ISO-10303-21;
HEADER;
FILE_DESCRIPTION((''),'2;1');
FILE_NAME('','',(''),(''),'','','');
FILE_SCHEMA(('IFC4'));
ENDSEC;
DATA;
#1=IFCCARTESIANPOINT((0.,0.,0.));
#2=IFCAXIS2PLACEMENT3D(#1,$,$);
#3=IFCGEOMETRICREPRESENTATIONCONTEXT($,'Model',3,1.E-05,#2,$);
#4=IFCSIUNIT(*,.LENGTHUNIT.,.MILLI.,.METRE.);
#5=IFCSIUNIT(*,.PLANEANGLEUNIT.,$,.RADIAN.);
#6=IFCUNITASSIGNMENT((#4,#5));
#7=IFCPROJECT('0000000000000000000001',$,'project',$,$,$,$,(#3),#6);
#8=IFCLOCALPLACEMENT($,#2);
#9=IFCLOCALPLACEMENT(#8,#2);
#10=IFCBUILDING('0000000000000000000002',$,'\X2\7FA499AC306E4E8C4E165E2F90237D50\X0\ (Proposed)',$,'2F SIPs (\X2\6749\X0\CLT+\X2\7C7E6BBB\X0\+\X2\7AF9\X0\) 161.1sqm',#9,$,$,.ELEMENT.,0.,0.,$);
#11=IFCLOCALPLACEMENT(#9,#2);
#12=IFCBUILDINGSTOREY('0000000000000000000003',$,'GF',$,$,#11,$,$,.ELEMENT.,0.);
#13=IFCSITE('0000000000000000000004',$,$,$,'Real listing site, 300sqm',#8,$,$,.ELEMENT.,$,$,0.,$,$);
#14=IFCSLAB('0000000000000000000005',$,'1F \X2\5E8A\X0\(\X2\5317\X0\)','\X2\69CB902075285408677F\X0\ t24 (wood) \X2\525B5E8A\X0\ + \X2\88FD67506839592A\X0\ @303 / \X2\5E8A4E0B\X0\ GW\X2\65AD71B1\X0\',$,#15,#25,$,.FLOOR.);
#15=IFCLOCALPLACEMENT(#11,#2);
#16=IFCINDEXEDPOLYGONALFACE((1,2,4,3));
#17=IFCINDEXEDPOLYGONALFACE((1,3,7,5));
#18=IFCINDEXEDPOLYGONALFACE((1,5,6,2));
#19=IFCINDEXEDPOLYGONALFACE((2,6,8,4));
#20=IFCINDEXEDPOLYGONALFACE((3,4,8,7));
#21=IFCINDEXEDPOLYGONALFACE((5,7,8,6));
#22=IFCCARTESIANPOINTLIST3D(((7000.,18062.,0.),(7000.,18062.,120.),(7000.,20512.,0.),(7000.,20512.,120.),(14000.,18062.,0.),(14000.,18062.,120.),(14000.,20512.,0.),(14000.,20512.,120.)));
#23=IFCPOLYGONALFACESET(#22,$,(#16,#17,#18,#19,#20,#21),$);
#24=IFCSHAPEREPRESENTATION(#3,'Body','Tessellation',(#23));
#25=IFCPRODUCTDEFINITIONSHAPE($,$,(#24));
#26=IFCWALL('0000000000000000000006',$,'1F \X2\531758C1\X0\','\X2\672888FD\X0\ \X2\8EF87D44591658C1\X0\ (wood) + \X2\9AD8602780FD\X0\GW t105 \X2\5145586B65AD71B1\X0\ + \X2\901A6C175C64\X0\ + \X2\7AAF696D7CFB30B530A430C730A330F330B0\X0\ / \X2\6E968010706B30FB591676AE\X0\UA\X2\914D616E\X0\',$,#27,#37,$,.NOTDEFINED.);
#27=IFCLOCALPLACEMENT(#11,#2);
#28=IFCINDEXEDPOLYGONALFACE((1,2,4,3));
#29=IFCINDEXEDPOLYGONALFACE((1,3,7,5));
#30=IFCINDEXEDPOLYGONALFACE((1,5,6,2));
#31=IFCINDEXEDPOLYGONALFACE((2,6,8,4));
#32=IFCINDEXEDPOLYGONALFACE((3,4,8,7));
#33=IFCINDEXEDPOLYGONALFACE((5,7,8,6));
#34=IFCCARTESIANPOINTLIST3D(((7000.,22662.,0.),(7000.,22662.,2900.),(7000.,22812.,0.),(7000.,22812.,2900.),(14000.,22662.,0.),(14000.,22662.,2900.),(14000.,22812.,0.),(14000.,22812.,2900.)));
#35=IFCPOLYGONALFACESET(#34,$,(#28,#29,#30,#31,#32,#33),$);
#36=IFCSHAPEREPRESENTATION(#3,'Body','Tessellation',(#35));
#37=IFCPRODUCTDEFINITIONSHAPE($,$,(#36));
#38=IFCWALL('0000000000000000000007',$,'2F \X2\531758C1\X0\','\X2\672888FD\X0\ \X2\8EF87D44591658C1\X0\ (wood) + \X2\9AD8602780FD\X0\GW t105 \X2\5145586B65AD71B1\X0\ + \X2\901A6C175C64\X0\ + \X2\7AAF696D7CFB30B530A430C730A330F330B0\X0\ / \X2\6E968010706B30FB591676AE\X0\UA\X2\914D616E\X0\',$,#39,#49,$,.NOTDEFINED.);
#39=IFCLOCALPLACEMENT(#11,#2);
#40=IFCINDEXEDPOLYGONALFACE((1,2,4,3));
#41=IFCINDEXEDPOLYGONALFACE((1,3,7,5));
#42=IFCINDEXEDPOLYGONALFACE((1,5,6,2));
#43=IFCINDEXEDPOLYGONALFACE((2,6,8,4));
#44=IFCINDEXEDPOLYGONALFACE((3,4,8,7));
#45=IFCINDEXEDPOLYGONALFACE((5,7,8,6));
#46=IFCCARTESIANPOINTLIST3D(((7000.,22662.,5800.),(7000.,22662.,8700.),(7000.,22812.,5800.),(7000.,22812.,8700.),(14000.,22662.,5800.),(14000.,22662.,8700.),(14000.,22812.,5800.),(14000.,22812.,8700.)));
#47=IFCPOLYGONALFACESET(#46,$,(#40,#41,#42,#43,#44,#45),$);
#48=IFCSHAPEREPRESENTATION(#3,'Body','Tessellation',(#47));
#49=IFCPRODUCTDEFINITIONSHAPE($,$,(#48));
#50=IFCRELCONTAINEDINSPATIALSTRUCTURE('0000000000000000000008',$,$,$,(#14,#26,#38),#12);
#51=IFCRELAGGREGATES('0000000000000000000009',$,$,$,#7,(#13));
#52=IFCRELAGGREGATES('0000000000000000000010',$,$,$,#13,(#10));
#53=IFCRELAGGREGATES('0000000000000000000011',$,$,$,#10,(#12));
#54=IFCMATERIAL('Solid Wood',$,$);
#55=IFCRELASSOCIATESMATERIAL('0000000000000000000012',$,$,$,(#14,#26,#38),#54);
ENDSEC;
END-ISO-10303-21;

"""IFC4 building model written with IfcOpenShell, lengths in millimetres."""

from ifc_helpers import new_model, si_unit, frame, frame_2d, origin, place, context, project, spatial, rectangle, extrude, material, element, save


model = new_model("IFC4")

# Units and contexts
model_context = context("Model", 3, precision=1e-05, world=origin())
ifc_project = project(units=[si_unit("LENGTHUNIT", "METRE", prefix="MILLI"), si_unit("PLANEANGLEUNIT", "RADIAN")], contexts=[model_context])

# Site, building, storey
site_placement = place(None, origin())
site = spatial("IfcSite", under=ifc_project, at=site_placement, ObjectType="Real listing site, 300sqm", CompositionType="ELEMENT", RefElevation=0.0)
building_placement = place(site_placement, origin())
building = spatial("IfcBuilding", under=site, at=building_placement, Name="群馬の二世帯連結 (Proposed)", ObjectType="2F SIPs (杉CLT+籾殻+竹) 161.1sqm", CompositionType="ELEMENT", ElevationOfRefHeight=0.0, ElevationOfTerrain=0.0)
storey_placement = place(building_placement, origin())
storey = spatial("IfcBuildingStorey", under=building, at=storey_placement, Name="GF", CompositionType="ELEMENT", Elevation=0.0)

# Slab
ifc_material_1 = material(Name="Solid Wood")
slab_1_placement = place(storey_placement, frame((3500.0, 9031.0, 0.0)))
element("IfcSlab", 1, at=slab_1_placement, inside=storey, material=ifc_material_1, Name="1F 床(北)", Description="構造用合板 t24 (wood) 剛床 + 製材根太 @303 / 床下 GW断熱", PredefinedType="FLOOR", context=model_context, shape_type="SweptSolid", body=[
    extrude(rectangle(XDim=7000.0, YDim=2450.0, at=frame_2d((3500.0, 1225.0))), frame((3500.0, 9031.0, 0.0)), (0.0, 0.0, 1.0), 120.0),
])

# Wall
wall_1_placement = place(storey_placement, frame((3500.0, 11331.0, 0.0)))
element("IfcWall", 2, at=wall_1_placement, inside=storey, material=ifc_material_1, Name="1F 北壁", Description="木製 軸組外壁 (wood) + 高性能GW t105 充填断熱 + 通気層 + 窯業系サイディング / 準耐火・外皮UA配慮", PredefinedType="NOTDEFINED", context=model_context, shape_type="SweptSolid", body=[
    extrude(rectangle(XDim=7000.0, YDim=150.0, at=frame_2d((3500.0, 75.0))), frame((3500.0, 11331.0, 0.0)), (0.0, 0.0, 1.0), 2900.0),
])

# Wall
wall_2_placement = place(storey_placement, frame((3500.0, 11331.0, 2900.0)))
element("IfcWall", 3, at=wall_2_placement, inside=storey, material=ifc_material_1, Name="2F 北壁", Description="木製 軸組外壁 (wood) + 高性能GW t105 充填断熱 + 通気層 + 窯業系サイディング / 準耐火・外皮UA配慮", PredefinedType="NOTDEFINED", context=model_context, shape_type="SweptSolid", body=[
    extrude(rectangle(XDim=7000.0, YDim=150.0, at=frame_2d((3500.0, 75.0))), frame((3500.0, 11331.0, 2900.0)), (0.0, 0.0, 1.0), 2900.0),
])

save(model, "model.ifc")
